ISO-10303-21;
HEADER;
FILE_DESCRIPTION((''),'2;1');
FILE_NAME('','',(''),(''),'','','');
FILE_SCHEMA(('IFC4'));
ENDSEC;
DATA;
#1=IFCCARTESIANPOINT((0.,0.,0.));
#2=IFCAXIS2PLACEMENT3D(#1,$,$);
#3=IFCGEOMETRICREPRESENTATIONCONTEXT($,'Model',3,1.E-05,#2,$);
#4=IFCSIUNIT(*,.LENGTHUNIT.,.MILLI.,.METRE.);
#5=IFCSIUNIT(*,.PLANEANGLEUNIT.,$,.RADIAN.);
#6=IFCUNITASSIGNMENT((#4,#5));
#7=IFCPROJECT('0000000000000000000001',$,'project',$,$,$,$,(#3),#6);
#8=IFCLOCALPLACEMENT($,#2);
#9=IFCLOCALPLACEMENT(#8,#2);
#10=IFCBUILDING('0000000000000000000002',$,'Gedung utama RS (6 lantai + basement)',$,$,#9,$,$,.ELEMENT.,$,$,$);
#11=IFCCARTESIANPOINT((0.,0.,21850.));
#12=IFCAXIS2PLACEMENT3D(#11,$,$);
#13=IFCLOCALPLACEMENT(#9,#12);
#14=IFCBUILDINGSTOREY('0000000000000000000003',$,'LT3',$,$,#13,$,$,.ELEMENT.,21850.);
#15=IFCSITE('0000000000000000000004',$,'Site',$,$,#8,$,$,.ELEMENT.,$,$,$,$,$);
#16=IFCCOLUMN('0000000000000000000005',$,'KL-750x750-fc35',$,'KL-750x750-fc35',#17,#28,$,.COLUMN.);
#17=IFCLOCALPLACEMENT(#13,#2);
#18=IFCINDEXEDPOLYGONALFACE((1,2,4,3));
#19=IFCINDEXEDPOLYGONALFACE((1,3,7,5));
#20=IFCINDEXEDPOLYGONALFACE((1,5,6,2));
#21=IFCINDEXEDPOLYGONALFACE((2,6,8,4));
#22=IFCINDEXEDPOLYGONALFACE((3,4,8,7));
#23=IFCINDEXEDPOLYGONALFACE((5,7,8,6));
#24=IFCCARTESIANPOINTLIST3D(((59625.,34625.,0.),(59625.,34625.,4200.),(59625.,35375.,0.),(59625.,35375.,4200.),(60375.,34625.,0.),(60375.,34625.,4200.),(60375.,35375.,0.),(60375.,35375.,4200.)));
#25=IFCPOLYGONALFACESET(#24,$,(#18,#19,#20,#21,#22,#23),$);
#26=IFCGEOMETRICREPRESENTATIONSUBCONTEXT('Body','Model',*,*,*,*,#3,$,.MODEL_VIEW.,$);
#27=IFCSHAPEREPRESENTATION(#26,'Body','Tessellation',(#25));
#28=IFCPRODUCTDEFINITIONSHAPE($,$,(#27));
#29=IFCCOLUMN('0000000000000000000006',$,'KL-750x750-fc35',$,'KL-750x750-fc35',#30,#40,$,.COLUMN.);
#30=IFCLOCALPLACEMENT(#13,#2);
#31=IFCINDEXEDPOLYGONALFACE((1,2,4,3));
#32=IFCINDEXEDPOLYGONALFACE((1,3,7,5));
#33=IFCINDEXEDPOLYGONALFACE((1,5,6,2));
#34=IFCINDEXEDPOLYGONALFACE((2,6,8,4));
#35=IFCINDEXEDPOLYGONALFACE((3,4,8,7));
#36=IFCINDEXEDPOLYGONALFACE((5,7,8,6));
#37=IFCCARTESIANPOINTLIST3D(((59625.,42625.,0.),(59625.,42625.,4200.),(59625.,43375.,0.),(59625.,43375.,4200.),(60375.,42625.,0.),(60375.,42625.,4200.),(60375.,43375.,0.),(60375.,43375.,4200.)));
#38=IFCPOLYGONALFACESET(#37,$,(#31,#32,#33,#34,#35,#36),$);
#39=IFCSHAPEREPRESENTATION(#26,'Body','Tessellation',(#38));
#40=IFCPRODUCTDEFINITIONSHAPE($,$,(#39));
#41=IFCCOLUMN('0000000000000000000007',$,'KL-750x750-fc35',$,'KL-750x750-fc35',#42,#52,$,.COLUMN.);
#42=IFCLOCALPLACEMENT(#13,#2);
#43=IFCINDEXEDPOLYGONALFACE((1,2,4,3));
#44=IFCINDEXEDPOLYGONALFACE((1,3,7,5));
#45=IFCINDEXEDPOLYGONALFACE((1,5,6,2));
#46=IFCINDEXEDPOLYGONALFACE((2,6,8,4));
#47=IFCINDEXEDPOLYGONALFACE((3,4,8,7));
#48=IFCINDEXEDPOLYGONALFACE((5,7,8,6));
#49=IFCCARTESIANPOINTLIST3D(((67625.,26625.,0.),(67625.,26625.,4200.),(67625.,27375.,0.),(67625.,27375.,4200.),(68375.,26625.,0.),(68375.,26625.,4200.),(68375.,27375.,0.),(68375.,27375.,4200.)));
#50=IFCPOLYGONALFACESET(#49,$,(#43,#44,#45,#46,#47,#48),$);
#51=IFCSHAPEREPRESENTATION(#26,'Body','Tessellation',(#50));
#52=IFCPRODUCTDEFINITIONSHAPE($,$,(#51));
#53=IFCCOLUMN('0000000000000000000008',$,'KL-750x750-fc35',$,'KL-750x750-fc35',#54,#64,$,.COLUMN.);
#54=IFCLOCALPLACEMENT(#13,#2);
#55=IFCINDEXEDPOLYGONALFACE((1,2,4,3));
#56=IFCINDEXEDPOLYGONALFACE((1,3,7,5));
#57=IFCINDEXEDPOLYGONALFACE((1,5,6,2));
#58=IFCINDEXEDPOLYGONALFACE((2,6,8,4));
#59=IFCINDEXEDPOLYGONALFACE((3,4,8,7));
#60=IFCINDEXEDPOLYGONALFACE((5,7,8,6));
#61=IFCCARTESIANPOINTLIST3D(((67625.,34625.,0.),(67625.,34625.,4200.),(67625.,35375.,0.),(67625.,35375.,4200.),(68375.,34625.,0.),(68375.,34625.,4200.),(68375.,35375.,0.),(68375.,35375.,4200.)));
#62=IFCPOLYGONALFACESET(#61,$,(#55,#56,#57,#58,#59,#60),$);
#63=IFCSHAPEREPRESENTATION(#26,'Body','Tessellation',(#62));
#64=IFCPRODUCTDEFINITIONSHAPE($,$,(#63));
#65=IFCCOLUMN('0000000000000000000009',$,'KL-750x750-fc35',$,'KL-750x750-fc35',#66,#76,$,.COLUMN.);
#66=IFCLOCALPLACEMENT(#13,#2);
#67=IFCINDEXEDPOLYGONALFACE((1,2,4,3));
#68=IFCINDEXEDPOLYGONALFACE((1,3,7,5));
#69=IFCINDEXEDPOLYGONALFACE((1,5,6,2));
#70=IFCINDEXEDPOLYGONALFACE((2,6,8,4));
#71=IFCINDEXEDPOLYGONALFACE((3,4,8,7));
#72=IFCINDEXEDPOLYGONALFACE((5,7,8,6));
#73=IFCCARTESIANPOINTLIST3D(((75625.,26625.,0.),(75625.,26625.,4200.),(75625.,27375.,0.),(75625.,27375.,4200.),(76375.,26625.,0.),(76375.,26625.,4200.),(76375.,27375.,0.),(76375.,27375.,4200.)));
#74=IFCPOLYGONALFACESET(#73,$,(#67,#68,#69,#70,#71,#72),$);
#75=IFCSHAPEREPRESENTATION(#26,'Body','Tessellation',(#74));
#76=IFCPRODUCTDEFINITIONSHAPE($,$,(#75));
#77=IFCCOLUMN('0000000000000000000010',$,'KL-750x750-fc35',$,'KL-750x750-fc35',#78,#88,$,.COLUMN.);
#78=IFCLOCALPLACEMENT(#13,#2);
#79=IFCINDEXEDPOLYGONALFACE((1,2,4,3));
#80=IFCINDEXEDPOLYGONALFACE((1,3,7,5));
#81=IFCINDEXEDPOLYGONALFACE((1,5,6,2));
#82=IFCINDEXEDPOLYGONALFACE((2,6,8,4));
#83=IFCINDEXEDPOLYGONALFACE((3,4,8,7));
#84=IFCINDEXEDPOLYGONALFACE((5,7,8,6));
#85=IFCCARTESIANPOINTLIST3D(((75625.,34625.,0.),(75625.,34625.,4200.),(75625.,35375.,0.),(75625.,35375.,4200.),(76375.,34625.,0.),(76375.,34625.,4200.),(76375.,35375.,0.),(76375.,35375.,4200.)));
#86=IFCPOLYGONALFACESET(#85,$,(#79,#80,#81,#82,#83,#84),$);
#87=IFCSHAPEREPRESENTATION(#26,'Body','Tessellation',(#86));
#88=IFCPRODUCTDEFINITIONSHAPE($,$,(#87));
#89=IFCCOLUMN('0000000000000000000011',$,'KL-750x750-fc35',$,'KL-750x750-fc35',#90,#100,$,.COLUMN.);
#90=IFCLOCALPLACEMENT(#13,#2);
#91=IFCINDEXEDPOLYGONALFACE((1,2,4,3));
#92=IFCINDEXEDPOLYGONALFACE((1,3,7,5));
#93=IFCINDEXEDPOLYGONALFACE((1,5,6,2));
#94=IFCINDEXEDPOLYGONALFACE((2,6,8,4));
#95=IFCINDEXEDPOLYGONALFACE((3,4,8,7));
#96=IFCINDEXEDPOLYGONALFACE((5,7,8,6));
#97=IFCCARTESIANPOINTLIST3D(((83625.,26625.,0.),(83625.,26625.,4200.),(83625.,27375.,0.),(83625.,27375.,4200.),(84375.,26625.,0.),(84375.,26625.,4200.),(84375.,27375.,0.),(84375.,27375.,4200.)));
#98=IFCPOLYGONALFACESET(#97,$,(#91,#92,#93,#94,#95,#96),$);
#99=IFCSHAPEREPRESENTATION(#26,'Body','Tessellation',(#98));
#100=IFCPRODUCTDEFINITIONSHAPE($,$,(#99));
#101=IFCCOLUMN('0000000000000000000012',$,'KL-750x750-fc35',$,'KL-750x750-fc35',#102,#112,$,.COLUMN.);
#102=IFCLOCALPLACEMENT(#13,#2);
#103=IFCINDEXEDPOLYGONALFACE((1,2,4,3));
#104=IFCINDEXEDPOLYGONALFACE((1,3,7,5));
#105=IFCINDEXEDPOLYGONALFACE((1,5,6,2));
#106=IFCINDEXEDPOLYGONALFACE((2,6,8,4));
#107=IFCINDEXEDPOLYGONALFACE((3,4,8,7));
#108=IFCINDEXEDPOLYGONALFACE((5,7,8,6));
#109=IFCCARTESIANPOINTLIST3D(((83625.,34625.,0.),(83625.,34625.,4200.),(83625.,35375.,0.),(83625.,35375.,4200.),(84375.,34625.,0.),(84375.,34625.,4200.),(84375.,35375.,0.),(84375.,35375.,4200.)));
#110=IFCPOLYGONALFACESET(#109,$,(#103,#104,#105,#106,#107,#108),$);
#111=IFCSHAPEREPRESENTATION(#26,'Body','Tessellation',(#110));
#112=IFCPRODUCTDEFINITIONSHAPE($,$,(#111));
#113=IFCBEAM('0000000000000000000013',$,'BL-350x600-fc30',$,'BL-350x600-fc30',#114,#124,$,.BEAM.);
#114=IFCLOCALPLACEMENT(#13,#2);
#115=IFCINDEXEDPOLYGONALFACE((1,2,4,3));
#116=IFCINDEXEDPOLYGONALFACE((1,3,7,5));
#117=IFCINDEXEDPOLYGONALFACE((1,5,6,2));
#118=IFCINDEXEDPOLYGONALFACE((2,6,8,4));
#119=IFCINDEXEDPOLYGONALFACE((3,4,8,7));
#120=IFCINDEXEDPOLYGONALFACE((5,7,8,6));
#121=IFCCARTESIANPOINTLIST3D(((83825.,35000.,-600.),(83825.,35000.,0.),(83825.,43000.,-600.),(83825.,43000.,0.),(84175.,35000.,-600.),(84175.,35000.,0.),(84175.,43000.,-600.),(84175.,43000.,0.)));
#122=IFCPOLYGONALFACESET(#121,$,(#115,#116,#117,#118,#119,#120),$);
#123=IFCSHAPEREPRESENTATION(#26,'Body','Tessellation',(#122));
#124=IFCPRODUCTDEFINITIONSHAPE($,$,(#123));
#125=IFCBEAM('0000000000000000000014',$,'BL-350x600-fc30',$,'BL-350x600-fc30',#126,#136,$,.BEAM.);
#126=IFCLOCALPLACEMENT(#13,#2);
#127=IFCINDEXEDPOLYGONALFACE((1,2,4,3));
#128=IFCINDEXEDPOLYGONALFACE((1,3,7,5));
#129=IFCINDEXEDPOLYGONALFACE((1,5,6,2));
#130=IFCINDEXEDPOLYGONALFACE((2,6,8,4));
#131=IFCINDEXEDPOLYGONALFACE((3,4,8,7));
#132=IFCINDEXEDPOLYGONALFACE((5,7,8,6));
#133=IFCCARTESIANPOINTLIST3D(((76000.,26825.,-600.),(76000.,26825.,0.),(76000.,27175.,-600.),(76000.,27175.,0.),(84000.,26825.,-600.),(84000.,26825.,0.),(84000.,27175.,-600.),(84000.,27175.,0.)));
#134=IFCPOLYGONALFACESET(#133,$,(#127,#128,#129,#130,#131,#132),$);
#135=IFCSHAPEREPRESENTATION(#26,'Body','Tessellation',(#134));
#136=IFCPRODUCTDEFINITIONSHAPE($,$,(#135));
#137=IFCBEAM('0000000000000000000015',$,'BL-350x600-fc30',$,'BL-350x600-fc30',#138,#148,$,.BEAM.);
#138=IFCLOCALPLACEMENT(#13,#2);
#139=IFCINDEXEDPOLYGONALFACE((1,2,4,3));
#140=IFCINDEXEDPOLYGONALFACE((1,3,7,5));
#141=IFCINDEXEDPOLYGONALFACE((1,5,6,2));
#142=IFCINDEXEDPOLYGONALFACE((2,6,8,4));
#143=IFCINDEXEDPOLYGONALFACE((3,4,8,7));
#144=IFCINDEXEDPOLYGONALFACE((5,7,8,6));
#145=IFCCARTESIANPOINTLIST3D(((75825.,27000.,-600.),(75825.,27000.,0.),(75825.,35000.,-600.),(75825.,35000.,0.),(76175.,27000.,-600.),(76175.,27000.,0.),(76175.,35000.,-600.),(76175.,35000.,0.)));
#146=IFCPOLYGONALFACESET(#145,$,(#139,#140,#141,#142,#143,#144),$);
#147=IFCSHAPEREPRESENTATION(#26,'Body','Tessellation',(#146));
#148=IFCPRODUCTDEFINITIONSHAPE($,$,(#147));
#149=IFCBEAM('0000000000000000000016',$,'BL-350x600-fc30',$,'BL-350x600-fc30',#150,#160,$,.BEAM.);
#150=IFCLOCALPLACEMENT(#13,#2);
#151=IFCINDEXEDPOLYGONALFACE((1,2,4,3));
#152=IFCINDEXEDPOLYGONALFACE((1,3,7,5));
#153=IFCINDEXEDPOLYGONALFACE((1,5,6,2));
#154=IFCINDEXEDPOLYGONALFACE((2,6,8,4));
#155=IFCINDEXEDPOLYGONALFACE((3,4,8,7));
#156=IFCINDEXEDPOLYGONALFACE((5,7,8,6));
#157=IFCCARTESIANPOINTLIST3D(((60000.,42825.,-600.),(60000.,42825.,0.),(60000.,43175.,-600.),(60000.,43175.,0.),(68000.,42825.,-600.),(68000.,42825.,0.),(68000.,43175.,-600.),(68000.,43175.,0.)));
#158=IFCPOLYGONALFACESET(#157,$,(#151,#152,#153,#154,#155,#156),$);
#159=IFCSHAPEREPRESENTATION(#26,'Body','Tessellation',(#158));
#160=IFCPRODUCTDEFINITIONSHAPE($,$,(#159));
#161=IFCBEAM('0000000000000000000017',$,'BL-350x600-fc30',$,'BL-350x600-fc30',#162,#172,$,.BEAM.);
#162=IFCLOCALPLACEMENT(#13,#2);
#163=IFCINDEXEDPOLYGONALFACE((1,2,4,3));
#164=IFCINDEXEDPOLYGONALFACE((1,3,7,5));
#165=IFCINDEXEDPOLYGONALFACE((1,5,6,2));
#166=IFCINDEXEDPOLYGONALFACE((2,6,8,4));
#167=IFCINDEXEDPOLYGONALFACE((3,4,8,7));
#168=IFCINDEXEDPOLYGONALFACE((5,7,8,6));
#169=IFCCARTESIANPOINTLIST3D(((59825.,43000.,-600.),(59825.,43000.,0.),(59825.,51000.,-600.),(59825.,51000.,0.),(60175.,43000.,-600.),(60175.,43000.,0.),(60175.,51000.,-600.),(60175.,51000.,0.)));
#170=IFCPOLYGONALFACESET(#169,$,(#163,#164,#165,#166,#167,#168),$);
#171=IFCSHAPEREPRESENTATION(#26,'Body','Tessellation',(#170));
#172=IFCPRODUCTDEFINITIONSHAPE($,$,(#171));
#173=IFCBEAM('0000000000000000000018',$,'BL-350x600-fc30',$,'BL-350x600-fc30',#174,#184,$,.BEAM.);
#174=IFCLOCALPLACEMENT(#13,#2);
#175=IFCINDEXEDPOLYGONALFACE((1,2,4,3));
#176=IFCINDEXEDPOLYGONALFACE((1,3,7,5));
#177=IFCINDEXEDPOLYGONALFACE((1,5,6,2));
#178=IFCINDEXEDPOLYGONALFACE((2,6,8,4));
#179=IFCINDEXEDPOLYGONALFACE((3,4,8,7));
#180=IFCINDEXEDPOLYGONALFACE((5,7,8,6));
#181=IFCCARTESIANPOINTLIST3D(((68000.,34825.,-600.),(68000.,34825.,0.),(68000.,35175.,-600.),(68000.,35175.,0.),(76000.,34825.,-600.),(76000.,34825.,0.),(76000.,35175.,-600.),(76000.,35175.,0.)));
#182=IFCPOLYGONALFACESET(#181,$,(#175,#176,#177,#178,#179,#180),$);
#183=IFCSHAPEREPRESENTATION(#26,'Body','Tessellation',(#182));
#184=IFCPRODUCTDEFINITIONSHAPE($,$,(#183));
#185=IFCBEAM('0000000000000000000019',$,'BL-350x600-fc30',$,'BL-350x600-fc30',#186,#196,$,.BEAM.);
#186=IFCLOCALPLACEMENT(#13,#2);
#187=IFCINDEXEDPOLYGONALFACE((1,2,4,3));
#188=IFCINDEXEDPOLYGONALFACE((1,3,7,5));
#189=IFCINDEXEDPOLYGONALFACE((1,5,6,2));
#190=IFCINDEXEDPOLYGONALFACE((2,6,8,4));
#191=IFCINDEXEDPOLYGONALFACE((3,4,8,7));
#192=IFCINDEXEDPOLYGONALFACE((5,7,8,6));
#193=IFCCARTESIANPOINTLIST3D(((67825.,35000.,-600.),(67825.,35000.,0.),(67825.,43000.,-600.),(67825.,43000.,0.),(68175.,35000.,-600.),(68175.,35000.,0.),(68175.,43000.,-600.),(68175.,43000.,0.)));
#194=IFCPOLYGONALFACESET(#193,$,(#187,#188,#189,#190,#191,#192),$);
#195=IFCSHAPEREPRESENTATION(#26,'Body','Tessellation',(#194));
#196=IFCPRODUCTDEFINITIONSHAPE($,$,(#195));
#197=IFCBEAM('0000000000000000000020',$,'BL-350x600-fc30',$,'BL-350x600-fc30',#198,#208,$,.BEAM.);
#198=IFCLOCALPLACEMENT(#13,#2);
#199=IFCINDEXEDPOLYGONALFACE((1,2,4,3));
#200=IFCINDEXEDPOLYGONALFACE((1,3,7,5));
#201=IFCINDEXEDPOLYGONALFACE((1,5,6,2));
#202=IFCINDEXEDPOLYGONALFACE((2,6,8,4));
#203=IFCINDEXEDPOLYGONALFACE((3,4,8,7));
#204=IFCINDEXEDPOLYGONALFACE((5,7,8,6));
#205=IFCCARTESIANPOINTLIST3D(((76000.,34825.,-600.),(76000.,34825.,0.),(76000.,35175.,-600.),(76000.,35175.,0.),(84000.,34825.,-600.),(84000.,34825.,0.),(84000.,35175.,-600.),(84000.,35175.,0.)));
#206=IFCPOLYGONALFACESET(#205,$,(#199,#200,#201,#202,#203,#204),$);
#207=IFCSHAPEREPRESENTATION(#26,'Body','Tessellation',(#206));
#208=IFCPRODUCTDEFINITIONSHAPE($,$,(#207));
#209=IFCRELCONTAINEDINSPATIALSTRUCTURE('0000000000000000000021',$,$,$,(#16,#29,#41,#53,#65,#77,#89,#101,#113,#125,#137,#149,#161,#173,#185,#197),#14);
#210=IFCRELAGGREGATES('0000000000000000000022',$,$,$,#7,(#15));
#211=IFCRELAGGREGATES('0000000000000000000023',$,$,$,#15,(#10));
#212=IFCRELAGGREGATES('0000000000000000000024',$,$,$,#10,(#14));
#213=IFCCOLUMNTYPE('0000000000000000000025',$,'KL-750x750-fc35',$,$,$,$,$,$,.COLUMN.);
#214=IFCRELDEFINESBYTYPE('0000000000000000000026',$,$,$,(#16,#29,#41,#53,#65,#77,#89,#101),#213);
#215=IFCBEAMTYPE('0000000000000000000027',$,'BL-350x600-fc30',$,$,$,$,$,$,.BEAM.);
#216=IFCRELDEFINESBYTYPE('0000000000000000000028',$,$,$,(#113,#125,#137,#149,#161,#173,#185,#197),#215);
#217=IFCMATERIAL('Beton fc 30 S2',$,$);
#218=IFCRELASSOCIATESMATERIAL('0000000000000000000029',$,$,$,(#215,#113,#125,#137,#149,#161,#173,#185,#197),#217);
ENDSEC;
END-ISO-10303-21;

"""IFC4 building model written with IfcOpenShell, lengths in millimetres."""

from ifc_helpers import new_model, si_unit, frame, origin, origin_2d, place, context, subcontext, project, spatial, rectangle, extrude, material, material_profile, profile_set, profile_usage, type_object, element, save


model = new_model("IFC4")

# Units and contexts
model_context = context("Model", 3, precision=1e-05, world=origin())
body_context = subcontext(model_context, "Body", "Model", "MODEL_VIEW")
ifc_project = project(units=[si_unit("LENGTHUNIT", "METRE", prefix="MILLI"), si_unit("PLANEANGLEUNIT", "RADIAN")], contexts=[model_context])

# Site, building, storey
site_placement = place(None, origin())
site = spatial("IfcSite", under=ifc_project, at=site_placement, Name="Site", CompositionType="ELEMENT")
building_placement = place(site_placement, origin())
building = spatial("IfcBuilding", under=site, at=building_placement, Name="Gedung utama RS (6 lantai + basement)", CompositionType="ELEMENT")
storey_placement = place(building_placement, frame((0.0, 0.0, 21850.0)))
storey = spatial("IfcBuildingStorey", under=building, at=storey_placement, Name="LT3", CompositionType="ELEMENT", Elevation=21850.0)

# Columns
ifc_material_profile_1 = material_profile(None, rectangle(XDim=750.0, YDim=750.0, at=origin_2d()), Name="KL-750x750-fc35")
ifc_profile_set_1 = profile_set([ifc_material_profile_1], Name="KL-750x750-fc35")
ifc_profile_usage_1 = profile_usage(ifc_profile_set_1, cardinal=5)
column_type = type_object("IfcColumnType", Name="KL-750x750-fc35", PredefinedType="COLUMN", material=ifc_profile_set_1)
for number, where, z_axis, x_axis, name in (
    (1, (60000.0, 35000.0, 0.0), (0.0, 0.0, 1.0), (1.0, 0.0, 0.0), "KL-750x750-fc35"),
    (2, (60000.0, 43000.0, 0.0), (0.0, 0.0, 1.0), (1.0, 0.0, 0.0), "KL-750x750-fc35"),
    (3, (68000.0, 27000.0, 0.0), (0.0, 0.0, 1.0), (1.0, 0.0, 0.0), "KL-750x750-fc35"),
    (4, (68000.0, 35000.0, 0.0), (0.0, 0.0, 1.0), (1.0, 0.0, 0.0), "KL-750x750-fc35"),
    (5, (76000.0, 27000.0, 0.0), (0.0, 0.0, 1.0), (1.0, 0.0, 0.0), "KL-750x750-fc35"),
    (6, (76000.0, 35000.0, 0.0), (0.0, 0.0, 1.0), (1.0, 0.0, 0.0), "KL-750x750-fc35"),
    (7, (84000.0, 27000.0, 0.0), (0.0, 0.0, 1.0), (1.0, 0.0, 0.0), "KL-750x750-fc35"),
    (8, (84000.0, 35000.0, 0.0), (0.0, 0.0, 1.0), (1.0, 0.0, 0.0), "KL-750x750-fc35"),
):
    element("IfcColumn", number, at=place(storey_placement, frame(where, z_axis=z_axis, x_axis=x_axis)), inside=storey, type_object=column_type, material=ifc_profile_usage_1, Name=name, ObjectType="KL-750x750-fc35", PredefinedType="COLUMN", context=body_context, shape_type="SweptSolid", body=[
        extrude(rectangle(XDim=750.0, YDim=750.0, at=origin_2d()), origin(), (0.0, 0.0, 1.0), 4200.0),
    ])

# Beams
ifc_material_1 = material(Name="Beton fc 30 S2")
ifc_material_profile_2 = material_profile(ifc_material_1, rectangle(XDim=350.0, YDim=600.0, at=origin_2d()), Name="BL-350x600-fc30")
ifc_profile_set_2 = profile_set([ifc_material_profile_2], Name="BL-350x600-fc30")
ifc_profile_usage_2 = profile_usage(ifc_profile_set_2, cardinal=8)
beam_type = type_object("IfcBeamType", Name="BL-350x600-fc30", PredefinedType="BEAM", material=ifc_profile_set_2)
beam_1_placement = place(storey_placement, frame((84000.0, 35000.0, -300.0)))
element("IfcBeam", 9, at=beam_1_placement, inside=storey, type_object=beam_type, material=ifc_profile_usage_2, Name="BL-350x600-fc30", ObjectType="BL-350x600-fc30", PredefinedType="BEAM", context=body_context, shape_type="SweptSolid", body=[
    extrude(rectangle(XDim=350.0, YDim=600.0, at=origin_2d()), frame((0.0, 0.0, 0.0), z_axis=(0.0, 1.0, 0.0), x_axis=(-1.0, 0.0, 0.0)), (0.0, 0.0, 1.0), 8000.0),
])
beam_2_placement = place(storey_placement, frame((76000.0, 27000.0, -300.0)))
element("IfcBeam", 10, at=beam_2_placement, inside=storey, type_object=beam_type, material=ifc_profile_usage_2, Name="BL-350x600-fc30", ObjectType="BL-350x600-fc30", PredefinedType="BEAM", context=body_context, shape_type="SweptSolid", body=[
    extrude(rectangle(XDim=350.0, YDim=600.0, at=origin_2d()), frame((0.0, 0.0, 0.0), z_axis=(1.0, 0.0, 0.0), x_axis=(0.0, 1.0, 0.0)), (0.0, 0.0, 1.0), 8000.0),
])
beam_3_placement = place(storey_placement, frame((76000.0, 27000.0, -300.0)))
element("IfcBeam", 11, at=beam_3_placement, inside=storey, type_object=beam_type, material=ifc_profile_usage_2, Name="BL-350x600-fc30", ObjectType="BL-350x600-fc30", PredefinedType="BEAM", context=body_context, shape_type="SweptSolid", body=[
    extrude(rectangle(XDim=350.0, YDim=600.0, at=origin_2d()), frame((0.0, 0.0, 0.0), z_axis=(0.0, 1.0, 0.0), x_axis=(-1.0, 0.0, 0.0)), (0.0, 0.0, 1.0), 8000.0),
])
beam_4_placement = place(storey_placement, frame((60000.0, 43000.0, -300.0)))
element("IfcBeam", 12, at=beam_4_placement, inside=storey, type_object=beam_type, material=ifc_profile_usage_2, Name="BL-350x600-fc30", ObjectType="BL-350x600-fc30", PredefinedType="BEAM", context=body_context, shape_type="SweptSolid", body=[
    extrude(rectangle(XDim=350.0, YDim=600.0, at=origin_2d()), frame((0.0, 0.0, 0.0), z_axis=(1.0, 0.0, 0.0), x_axis=(0.0, 1.0, 0.0)), (0.0, 0.0, 1.0), 8000.0),
])
beam_5_placement = place(storey_placement, frame((60000.0, 43000.0, -300.0)))
element("IfcBeam", 13, at=beam_5_placement, inside=storey, type_object=beam_type, material=ifc_profile_usage_2, Name="BL-350x600-fc30", ObjectType="BL-350x600-fc30", PredefinedType="BEAM", context=body_context, shape_type="SweptSolid", body=[
    extrude(rectangle(XDim=350.0, YDim=600.0, at=origin_2d()), frame((0.0, 0.0, 0.0), z_axis=(0.0, 1.0, 0.0), x_axis=(-1.0, 0.0, 0.0)), (0.0, 0.0, 1.0), 8000.0),
])
beam_6_placement = place(storey_placement, frame((68000.0, 35000.0, -300.0)))
element("IfcBeam", 14, at=beam_6_placement, inside=storey, type_object=beam_type, material=ifc_profile_usage_2, Name="BL-350x600-fc30", ObjectType="BL-350x600-fc30", PredefinedType="BEAM", context=body_context, shape_type="SweptSolid", body=[
    extrude(rectangle(XDim=350.0, YDim=600.0, at=origin_2d()), frame((0.0, 0.0, 0.0), z_axis=(1.0, 0.0, 0.0), x_axis=(0.0, 1.0, 0.0)), (0.0, 0.0, 1.0), 8000.0),
])
beam_7_placement = place(storey_placement, frame((68000.0, 35000.0, -300.0)))
element("IfcBeam", 15, at=beam_7_placement, inside=storey, type_object=beam_type, material=ifc_profile_usage_2, Name="BL-350x600-fc30", ObjectType="BL-350x600-fc30", PredefinedType="BEAM", context=body_context, shape_type="SweptSolid", body=[
    extrude(rectangle(XDim=350.0, YDim=600.0, at=origin_2d()), frame((0.0, 0.0, 0.0), z_axis=(0.0, 1.0, 0.0), x_axis=(-1.0, 0.0, 0.0)), (0.0, 0.0, 1.0), 8000.0),
])
beam_8_placement = place(storey_placement, frame((76000.0, 35000.0, -300.0)))
element("IfcBeam", 16, at=beam_8_placement, inside=storey, type_object=beam_type, material=ifc_profile_usage_2, Name="BL-350x600-fc30", ObjectType="BL-350x600-fc30", PredefinedType="BEAM", context=body_context, shape_type="SweptSolid", body=[
    extrude(rectangle(XDim=350.0, YDim=600.0, at=origin_2d()), frame((0.0, 0.0, 0.0), z_axis=(1.0, 0.0, 0.0), x_axis=(0.0, 1.0, 0.0)), (0.0, 0.0, 1.0), 8000.0),
])

save(model, "model.ifc")
